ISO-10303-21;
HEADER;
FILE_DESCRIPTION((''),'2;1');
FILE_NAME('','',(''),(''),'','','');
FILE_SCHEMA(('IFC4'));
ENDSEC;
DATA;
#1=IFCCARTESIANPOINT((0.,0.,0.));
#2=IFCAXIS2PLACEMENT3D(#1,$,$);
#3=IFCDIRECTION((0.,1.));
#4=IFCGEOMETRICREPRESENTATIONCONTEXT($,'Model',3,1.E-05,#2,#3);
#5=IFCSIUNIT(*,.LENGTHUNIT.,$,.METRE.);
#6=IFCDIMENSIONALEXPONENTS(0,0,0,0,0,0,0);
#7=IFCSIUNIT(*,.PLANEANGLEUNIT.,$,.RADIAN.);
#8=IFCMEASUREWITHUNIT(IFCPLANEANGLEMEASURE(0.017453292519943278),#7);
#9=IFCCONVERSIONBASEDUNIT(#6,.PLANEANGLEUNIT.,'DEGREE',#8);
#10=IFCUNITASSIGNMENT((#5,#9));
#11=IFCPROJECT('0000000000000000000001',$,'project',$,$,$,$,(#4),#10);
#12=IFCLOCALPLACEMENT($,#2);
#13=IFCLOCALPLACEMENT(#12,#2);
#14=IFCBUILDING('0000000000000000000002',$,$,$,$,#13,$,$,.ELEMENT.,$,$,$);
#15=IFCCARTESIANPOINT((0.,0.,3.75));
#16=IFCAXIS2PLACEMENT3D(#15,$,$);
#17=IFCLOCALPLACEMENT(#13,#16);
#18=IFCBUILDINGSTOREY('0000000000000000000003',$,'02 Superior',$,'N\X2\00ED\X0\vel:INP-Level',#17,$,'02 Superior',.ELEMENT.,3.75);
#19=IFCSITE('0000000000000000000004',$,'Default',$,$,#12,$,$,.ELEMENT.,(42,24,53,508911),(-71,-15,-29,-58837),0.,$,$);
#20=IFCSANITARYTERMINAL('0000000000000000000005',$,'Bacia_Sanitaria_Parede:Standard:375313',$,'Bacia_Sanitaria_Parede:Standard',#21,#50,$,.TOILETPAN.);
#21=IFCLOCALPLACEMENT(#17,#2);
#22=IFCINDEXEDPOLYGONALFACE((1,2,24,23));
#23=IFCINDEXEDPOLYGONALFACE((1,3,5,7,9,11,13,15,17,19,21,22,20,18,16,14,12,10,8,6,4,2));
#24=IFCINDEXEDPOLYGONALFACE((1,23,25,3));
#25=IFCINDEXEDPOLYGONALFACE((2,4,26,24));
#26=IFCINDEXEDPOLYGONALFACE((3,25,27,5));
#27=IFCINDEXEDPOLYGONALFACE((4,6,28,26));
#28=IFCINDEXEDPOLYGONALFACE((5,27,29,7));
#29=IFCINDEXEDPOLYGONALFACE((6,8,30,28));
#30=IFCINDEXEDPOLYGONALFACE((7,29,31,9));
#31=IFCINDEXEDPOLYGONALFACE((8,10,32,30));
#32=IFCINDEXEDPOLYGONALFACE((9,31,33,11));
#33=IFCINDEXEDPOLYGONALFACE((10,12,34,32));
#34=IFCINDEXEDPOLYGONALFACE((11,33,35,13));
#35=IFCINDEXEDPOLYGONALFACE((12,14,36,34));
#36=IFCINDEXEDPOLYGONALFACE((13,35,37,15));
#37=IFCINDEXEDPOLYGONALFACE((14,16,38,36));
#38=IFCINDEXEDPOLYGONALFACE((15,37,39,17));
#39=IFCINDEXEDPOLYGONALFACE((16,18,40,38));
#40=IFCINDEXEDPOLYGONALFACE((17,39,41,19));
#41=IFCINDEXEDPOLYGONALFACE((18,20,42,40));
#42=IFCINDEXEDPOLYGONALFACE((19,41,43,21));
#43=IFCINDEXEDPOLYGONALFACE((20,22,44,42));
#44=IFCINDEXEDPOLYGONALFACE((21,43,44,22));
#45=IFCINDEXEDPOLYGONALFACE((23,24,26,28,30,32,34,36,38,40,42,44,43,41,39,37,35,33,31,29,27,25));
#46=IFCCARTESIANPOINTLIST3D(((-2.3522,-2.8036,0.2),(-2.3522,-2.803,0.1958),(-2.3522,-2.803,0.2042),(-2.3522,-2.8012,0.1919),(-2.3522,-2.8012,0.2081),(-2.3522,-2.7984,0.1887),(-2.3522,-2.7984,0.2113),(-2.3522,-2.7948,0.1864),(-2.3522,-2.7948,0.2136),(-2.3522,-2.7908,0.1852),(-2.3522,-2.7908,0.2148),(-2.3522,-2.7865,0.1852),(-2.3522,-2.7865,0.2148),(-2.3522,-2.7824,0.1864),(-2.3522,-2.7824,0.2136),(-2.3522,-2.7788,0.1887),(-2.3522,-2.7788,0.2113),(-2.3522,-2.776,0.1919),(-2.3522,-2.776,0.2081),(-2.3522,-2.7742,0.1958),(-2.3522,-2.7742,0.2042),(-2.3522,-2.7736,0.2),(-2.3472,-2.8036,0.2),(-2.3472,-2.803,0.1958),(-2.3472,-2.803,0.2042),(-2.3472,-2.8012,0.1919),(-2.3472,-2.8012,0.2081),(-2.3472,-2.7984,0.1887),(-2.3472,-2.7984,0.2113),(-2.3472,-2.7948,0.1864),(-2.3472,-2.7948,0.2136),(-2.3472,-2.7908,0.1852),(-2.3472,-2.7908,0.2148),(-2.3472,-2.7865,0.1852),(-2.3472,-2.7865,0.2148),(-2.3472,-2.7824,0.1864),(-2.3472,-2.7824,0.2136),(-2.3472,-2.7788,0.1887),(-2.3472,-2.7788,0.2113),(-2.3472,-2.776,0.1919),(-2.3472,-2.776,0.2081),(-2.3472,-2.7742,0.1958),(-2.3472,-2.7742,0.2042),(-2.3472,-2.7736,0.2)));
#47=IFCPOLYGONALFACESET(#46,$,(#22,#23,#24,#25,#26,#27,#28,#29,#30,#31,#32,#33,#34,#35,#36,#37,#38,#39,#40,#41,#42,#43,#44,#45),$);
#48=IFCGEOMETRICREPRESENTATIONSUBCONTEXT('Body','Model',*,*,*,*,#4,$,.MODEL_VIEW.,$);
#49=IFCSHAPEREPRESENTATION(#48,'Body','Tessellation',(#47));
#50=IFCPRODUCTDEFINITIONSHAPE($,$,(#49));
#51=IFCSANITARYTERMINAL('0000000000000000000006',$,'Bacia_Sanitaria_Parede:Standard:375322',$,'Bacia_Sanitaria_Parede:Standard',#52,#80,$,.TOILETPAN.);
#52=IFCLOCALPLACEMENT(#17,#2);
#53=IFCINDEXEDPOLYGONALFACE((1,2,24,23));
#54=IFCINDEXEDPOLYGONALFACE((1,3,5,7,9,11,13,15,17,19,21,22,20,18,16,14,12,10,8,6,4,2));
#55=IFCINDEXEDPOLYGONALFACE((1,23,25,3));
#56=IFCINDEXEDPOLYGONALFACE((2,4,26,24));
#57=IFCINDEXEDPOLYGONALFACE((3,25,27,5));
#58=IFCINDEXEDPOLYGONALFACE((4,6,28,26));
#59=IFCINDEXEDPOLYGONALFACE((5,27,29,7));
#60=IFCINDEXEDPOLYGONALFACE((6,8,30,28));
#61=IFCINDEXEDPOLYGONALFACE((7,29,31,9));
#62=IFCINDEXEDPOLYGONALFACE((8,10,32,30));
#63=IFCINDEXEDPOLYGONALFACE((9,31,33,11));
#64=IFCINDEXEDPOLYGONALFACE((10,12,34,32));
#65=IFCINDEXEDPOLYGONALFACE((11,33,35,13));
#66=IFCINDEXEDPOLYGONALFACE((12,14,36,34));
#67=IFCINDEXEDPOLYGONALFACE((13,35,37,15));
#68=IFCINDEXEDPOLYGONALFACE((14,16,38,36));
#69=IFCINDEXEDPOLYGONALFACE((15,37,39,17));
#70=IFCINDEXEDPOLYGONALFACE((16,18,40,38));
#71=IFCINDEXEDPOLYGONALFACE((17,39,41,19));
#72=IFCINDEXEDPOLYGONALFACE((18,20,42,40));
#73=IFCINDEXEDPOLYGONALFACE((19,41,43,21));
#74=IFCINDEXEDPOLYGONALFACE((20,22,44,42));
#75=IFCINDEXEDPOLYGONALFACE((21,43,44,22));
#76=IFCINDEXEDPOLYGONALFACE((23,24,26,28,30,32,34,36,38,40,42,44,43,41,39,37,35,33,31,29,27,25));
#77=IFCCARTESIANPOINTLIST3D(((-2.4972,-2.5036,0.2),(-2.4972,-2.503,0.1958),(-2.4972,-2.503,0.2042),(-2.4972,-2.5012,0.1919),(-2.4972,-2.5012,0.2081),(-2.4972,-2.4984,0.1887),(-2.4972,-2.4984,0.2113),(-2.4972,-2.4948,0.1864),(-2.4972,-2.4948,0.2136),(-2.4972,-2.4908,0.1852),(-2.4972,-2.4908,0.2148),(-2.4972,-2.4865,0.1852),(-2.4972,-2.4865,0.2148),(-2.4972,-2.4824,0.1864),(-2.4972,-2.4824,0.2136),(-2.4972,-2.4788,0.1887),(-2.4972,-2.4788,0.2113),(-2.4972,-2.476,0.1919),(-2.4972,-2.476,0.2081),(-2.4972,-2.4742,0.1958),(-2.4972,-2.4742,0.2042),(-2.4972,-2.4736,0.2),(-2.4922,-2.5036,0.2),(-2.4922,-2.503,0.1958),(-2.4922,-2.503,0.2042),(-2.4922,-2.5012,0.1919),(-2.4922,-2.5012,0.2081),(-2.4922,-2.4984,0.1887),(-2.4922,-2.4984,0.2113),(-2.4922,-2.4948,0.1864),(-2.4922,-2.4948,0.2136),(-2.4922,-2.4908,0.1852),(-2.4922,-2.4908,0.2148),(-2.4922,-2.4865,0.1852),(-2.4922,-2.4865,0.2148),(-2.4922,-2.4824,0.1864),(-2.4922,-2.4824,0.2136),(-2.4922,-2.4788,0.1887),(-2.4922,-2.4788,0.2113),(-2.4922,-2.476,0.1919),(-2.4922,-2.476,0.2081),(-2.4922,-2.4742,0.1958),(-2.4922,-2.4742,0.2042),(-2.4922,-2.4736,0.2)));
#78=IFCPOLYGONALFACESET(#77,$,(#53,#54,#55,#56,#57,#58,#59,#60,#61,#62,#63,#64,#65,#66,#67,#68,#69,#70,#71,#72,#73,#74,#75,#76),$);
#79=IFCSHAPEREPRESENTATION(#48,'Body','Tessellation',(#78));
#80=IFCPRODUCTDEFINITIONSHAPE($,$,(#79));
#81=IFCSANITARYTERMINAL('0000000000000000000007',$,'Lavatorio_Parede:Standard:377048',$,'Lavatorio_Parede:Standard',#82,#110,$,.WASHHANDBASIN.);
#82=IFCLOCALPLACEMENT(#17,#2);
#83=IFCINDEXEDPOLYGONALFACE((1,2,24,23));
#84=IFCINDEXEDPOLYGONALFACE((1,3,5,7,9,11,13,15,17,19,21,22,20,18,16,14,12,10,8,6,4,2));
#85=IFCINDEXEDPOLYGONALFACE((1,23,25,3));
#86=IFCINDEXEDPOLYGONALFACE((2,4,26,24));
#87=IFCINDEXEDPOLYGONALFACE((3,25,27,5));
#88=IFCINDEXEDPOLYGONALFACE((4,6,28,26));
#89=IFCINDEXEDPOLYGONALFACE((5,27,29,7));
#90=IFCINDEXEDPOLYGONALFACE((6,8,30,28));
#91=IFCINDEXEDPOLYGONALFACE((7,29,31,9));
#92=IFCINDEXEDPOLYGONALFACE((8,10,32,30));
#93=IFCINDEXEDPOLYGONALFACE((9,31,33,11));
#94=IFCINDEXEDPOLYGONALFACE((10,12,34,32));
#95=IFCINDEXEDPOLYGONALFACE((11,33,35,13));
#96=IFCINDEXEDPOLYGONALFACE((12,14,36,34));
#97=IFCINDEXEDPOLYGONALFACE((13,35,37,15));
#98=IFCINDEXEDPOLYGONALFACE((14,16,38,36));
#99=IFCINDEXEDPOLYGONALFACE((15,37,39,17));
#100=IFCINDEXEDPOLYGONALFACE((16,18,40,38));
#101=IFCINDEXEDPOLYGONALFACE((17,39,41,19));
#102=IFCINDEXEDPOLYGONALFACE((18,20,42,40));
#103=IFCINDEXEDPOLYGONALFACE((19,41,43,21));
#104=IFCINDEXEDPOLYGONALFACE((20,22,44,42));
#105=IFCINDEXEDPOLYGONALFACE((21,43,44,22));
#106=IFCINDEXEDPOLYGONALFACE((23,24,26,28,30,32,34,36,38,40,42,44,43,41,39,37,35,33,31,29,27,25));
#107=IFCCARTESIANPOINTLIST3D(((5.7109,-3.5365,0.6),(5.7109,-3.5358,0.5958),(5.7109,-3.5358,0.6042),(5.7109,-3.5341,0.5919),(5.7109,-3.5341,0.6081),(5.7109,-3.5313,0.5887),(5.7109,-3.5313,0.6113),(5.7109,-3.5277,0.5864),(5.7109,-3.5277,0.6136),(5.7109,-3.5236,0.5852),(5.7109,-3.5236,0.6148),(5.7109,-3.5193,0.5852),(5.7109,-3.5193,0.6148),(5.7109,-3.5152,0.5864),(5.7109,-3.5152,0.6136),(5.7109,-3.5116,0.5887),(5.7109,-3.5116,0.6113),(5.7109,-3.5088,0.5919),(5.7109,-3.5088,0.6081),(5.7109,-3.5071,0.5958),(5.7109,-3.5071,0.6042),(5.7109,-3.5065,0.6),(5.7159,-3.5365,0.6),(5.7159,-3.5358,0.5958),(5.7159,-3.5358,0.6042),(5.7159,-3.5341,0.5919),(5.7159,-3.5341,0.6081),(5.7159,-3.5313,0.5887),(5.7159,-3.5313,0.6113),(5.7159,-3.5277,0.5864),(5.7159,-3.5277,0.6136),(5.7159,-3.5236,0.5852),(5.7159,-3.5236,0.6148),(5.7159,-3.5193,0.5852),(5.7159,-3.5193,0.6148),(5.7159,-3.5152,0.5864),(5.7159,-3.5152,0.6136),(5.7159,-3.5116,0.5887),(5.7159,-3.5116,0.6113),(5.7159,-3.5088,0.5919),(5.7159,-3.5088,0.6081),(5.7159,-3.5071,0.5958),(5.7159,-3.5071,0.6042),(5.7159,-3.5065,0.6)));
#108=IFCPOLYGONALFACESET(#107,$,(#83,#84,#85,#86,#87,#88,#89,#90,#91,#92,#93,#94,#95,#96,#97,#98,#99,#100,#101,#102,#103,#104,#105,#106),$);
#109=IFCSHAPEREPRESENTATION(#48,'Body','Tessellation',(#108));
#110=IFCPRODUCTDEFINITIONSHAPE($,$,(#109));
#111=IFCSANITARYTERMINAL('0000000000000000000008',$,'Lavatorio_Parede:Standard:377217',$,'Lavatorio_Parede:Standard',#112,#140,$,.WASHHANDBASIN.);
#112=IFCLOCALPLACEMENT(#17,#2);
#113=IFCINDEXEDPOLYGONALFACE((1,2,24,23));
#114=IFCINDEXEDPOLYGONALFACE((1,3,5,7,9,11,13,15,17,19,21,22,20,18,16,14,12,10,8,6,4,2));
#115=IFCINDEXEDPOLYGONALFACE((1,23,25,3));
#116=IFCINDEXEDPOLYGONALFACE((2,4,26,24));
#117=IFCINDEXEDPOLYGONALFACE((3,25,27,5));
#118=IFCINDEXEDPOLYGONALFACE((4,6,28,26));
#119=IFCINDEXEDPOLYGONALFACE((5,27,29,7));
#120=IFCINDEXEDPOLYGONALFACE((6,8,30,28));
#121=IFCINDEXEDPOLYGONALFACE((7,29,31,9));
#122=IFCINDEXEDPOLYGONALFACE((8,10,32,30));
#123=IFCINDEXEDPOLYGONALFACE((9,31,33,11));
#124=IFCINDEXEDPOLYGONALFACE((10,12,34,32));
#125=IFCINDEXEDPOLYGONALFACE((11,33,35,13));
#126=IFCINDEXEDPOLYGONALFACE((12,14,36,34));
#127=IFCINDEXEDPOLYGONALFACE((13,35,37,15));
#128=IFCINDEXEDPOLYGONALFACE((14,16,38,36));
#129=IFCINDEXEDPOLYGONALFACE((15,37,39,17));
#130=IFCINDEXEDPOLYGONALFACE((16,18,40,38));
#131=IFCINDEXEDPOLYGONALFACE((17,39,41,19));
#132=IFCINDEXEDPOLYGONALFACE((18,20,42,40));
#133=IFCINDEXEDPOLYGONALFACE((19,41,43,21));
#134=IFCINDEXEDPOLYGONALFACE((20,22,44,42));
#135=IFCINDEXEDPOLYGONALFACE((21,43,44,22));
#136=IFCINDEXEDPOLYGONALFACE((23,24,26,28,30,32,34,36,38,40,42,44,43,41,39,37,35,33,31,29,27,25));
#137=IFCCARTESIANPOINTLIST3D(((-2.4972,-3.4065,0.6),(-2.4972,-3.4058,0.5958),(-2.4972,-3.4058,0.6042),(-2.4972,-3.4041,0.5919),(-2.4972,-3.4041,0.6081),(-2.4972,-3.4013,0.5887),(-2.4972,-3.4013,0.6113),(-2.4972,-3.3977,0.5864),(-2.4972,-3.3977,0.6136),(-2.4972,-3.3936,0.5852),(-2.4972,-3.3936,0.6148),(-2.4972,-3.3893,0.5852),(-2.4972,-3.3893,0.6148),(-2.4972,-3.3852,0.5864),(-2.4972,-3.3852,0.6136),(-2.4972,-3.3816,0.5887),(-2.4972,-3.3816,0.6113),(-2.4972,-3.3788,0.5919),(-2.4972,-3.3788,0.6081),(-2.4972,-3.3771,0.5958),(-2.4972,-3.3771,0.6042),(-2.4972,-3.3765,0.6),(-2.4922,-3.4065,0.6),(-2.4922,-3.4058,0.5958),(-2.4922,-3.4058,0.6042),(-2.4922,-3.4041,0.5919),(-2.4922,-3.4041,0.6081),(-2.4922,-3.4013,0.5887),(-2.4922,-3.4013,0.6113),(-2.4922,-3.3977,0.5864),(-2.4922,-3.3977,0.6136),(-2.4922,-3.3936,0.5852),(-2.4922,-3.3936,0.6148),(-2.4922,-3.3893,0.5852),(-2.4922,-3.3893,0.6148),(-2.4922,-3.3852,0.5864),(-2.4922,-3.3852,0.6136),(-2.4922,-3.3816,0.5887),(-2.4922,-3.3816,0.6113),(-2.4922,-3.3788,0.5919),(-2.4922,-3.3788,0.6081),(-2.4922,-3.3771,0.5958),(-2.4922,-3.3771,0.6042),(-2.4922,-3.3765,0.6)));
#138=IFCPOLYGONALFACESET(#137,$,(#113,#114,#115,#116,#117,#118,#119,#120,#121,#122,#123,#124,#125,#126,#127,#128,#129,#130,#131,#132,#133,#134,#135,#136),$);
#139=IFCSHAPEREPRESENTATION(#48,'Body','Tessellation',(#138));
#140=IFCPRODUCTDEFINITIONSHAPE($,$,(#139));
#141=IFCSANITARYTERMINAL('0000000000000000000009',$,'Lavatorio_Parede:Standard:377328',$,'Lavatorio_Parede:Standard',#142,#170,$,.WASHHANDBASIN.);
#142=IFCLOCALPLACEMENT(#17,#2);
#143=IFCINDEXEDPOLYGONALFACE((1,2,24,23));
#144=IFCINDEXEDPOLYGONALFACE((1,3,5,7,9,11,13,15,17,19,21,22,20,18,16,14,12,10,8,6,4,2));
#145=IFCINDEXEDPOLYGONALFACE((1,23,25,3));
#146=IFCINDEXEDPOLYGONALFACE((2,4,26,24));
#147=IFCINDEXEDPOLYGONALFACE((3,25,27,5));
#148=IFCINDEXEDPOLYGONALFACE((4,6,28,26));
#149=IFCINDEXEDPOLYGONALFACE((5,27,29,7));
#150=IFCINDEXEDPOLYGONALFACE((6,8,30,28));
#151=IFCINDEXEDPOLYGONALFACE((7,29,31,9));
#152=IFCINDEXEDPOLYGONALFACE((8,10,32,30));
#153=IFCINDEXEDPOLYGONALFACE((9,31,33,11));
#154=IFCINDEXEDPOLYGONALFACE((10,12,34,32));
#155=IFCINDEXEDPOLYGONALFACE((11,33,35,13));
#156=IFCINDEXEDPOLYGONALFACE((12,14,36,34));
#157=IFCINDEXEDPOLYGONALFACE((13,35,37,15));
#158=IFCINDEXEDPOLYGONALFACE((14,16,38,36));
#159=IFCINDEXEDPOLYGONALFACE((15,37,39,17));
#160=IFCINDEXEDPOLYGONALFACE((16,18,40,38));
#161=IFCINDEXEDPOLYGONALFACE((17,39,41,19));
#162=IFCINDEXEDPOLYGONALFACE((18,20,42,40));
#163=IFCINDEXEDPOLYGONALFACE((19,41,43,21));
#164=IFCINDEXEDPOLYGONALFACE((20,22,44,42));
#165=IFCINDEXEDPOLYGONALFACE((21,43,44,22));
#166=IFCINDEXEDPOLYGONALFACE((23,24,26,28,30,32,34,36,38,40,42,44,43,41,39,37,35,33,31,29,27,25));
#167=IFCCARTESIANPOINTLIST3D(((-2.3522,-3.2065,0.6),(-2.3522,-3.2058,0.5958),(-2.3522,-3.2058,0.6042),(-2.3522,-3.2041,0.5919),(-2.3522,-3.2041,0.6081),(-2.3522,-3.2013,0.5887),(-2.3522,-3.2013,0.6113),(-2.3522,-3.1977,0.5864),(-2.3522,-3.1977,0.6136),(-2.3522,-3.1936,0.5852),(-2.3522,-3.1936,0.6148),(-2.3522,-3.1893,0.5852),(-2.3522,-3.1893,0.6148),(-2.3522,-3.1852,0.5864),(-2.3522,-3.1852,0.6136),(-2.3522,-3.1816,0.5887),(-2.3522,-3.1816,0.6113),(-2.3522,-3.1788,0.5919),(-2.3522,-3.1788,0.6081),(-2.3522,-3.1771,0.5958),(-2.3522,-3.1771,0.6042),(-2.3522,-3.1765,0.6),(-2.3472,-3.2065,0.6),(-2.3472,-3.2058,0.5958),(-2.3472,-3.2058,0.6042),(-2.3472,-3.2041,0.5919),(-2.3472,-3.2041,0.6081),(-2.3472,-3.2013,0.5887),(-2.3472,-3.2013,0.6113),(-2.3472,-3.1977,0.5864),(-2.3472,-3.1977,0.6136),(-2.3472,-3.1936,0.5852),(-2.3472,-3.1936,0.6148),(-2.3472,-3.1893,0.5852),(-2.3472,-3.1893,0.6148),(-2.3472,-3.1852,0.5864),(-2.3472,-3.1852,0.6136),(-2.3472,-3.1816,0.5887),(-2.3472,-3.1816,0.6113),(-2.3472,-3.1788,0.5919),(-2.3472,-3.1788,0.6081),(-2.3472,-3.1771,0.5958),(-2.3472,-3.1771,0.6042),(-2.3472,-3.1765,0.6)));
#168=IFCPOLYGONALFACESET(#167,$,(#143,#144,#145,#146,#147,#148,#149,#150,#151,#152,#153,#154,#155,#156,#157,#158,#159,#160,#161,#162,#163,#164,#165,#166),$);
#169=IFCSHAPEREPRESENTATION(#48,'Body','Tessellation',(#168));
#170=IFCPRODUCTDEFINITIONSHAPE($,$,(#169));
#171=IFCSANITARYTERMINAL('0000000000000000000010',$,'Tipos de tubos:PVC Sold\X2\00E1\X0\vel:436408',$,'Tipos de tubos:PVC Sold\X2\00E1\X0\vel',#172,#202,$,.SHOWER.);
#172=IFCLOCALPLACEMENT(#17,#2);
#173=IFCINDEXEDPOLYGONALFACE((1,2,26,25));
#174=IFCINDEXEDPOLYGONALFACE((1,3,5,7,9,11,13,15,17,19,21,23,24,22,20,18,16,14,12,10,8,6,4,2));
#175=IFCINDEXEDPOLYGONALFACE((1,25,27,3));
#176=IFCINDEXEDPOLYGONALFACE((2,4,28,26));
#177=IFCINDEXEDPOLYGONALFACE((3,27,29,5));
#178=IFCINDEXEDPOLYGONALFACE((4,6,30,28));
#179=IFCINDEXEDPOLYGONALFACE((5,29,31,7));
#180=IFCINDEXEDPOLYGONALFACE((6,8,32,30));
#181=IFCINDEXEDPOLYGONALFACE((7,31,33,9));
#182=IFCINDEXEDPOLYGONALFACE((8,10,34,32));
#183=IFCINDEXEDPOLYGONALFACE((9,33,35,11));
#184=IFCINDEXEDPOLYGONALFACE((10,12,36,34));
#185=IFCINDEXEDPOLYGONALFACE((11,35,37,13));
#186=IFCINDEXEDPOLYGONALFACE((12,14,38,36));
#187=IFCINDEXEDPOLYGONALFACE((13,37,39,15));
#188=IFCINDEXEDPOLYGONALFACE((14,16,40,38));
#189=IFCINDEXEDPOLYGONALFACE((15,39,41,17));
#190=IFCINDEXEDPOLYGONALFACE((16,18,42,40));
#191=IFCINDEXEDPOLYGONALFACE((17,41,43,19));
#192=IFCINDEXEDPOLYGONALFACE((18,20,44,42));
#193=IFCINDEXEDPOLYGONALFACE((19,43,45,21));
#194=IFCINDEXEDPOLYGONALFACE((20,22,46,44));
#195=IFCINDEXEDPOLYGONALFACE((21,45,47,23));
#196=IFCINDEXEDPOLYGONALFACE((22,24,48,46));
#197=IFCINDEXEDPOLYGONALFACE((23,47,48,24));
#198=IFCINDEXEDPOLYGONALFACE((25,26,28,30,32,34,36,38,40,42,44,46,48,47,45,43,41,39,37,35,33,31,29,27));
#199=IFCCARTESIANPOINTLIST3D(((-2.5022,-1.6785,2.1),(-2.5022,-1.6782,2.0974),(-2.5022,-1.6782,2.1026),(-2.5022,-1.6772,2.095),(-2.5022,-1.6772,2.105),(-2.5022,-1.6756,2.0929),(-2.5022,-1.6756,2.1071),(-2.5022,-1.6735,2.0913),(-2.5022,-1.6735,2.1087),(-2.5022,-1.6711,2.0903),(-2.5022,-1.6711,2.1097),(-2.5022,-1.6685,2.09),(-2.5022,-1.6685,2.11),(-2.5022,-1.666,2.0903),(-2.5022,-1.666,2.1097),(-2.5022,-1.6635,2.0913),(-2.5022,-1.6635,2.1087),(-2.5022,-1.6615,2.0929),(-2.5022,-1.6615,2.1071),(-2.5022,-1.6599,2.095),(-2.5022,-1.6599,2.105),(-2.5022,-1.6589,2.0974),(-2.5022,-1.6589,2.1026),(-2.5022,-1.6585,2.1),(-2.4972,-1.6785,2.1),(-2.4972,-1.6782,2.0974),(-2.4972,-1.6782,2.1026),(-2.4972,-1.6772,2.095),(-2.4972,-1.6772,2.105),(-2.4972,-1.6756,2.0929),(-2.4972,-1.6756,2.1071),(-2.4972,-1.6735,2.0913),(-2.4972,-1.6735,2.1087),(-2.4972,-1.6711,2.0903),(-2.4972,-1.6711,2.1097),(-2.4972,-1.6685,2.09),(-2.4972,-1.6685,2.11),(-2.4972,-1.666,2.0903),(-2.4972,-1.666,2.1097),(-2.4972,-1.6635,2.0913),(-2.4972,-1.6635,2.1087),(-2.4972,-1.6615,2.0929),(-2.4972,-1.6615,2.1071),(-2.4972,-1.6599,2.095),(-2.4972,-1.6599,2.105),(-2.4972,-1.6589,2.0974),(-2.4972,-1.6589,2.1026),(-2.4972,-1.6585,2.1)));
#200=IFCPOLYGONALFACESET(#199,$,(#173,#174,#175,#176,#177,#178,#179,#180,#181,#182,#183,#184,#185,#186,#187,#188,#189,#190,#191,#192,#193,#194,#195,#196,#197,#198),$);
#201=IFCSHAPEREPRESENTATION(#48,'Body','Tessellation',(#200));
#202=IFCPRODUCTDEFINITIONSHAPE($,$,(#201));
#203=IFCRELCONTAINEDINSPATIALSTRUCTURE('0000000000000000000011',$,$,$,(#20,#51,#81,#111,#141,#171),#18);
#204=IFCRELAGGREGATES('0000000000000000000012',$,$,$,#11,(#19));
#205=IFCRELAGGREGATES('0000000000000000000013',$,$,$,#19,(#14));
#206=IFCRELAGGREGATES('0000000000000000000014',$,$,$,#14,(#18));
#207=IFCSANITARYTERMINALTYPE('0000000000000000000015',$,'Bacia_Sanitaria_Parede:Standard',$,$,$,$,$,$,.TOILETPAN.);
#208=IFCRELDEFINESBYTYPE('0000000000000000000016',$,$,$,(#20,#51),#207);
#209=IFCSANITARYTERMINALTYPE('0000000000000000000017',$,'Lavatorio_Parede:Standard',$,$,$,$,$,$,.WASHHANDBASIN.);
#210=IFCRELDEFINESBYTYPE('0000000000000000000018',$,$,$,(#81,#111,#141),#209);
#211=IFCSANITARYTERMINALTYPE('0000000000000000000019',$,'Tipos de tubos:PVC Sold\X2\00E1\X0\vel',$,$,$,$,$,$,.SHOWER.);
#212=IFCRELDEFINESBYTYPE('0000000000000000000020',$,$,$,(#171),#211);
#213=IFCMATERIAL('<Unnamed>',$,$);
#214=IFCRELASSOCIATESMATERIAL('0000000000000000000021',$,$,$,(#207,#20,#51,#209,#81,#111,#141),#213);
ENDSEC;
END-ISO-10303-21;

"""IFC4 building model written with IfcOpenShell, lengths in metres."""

from ifc_helpers import new_model, entity, si_unit, converted_unit, direction, frame, origin, place, context, subcontext, project, spatial, arc, indexed_curve, outline, extrude, source, transform, mapped, material, type_object, type_shapes, element, save


model = new_model("IFC4")

# Units and contexts
model_context = context("Model", 3, precision=1e-05, world=origin(), true_north=direction((0.0, 1.0)))
body_context = subcontext(model_context, "Body", "Model", "MODEL_VIEW")
ifc_project = project(units=[si_unit("LENGTHUNIT", "METRE"), converted_unit("PLANEANGLEUNIT", "DEGREE", entity("IfcPlaneAngleMeasure", 0.017453292519943278), si_unit("PLANEANGLEUNIT", "RADIAN"), dimensions=[0, 0, 0, 0, 0, 0, 0])], contexts=[model_context])

# Site, building, storey
site_placement = place(None, origin())
site = spatial("IfcSite", under=ifc_project, at=site_placement, Name="Default", CompositionType="ELEMENT", RefLatitude=(42, 24, 53, 508911), RefLongitude=(-71, -15, -29, -58837), RefElevation=0.0)
building_placement = place(site_placement, origin())
building = spatial("IfcBuilding", under=site, at=building_placement, CompositionType="ELEMENT")
storey_placement = place(building_placement, frame((0.0, 0.0, 3.75)))
storey = spatial("IfcBuildingStorey", under=building, at=storey_placement, Name="02 Superior", ObjectType="Nível:INP-Level", LongName="02 Superior", CompositionType="ELEMENT", Elevation=3.75)

# Sanitary terminals
ifc_material = material(Name="<Unnamed>")
sanitary_terminal_type_1 = type_object("IfcSanitaryTerminalType", Name="Bacia_Sanitaria_Parede:Standard", PredefinedType="TOILETPAN", material=ifc_material)
shared_shape_1 = source(origin(), body_context, "Body", "SweptSolid", [
    extrude(outline(indexed_curve([(-0.015, 0.0), (0.0, -0.015), (0.015, 0.0), (0.0, 0.015)], segments=[arc(1, 2, 3), arc(3, 4, 1)], self_intersect=False)), frame((0.15, -0.005, 0.2), z_axis=(0.0, 1.0, 0.0), x_axis=(1.0, 0.0, 0.0)), (0.0, 0.0, 1.0), 0.005),
])
type_shapes(sanitary_terminal_type_1, [shared_shape_1])
for number, where, z_axis, x_axis, name in (
    (1, (-2.3472, -2.6386, 0.0), (0.0, 0.0, 1.0), (0.0, -1.0, 0.0), "Bacia_Sanitaria_Parede:Standard:375313"),
    (2, (-2.4972, -2.6386, 0.0), (0.0, 0.0, 1.0), (0.0, 1.0, 0.0), "Bacia_Sanitaria_Parede:Standard:375322"),
):
    element("IfcSanitaryTerminal", number, at=place(storey_placement, frame(where, z_axis=z_axis, x_axis=x_axis)), inside=storey, type_object=sanitary_terminal_type_1, material=ifc_material, Name=name, ObjectType="Bacia_Sanitaria_Parede:Standard", PredefinedType="TOILETPAN", context=body_context, shape_type="MappedRepresentation", body=[
        mapped(shared_shape_1, transform((0.0, 0.0, 0.0), scale=1.0)),
    ])
sanitary_terminal_type_2 = type_object("IfcSanitaryTerminalType", Name="Lavatorio_Parede:Standard", PredefinedType="WASHHANDBASIN", material=ifc_material)
shared_shape_2 = source(origin(), body_context, "Body", "SweptSolid", [
    extrude(outline(indexed_curve([(-0.015, 0.0), (0.0, -0.015), (0.015, 0.0), (0.0, 0.015)], segments=[arc(1, 2, 3), arc(3, 4, 1)], self_intersect=False)), frame((-0.1, -0.005, 0.6), z_axis=(0.0, 1.0, 0.0), x_axis=(1.0, 0.0, 0.0)), (0.0, 0.0, 1.0), 0.005),
])
type_shapes(sanitary_terminal_type_2, [shared_shape_2])
for number, where, z_axis, x_axis, name in (
    (3, (5.7109, -3.4215, 0.0), (0.0, 0.0, 1.0), (0.0, 1.0, 0.0), "Lavatorio_Parede:Standard:377048"),
    (4, (-2.4972, -3.2915, 0.0), (0.0, 0.0, 1.0), (0.0, 1.0, 0.0), "Lavatorio_Parede:Standard:377217"),
    (5, (-2.3472, -3.2915, 0.0), (0.0, 0.0, 1.0), (0.0, -1.0, 0.0), "Lavatorio_Parede:Standard:377328"),
):
    element("IfcSanitaryTerminal", number, at=place(storey_placement, frame(where, z_axis=z_axis, x_axis=x_axis)), inside=storey, type_object=sanitary_terminal_type_2, material=ifc_material, Name=name, ObjectType="Lavatorio_Parede:Standard", PredefinedType="WASHHANDBASIN", context=body_context, shape_type="MappedRepresentation", body=[
        mapped(shared_shape_2, transform((0.0, 0.0, 0.0), scale=1.0)),
    ])
sanitary_terminal_type_3 = type_object("IfcSanitaryTerminalType", Name="Tipos de tubos:PVC Soldável", PredefinedType="SHOWER")
sanitary_terminal_1_placement = place(storey_placement, origin())
element("IfcSanitaryTerminal", 6, at=sanitary_terminal_1_placement, inside=storey, type_object=sanitary_terminal_type_3, Name="Tipos de tubos:PVC Soldável:436408", ObjectType="Tipos de tubos:PVC Soldável", PredefinedType="SHOWER", context=body_context, shape_type="SweptSolid", body=[
    extrude(outline(indexed_curve([(0.01, 0.0), (0.0071, 0.0071), (0.0, 0.01), (-0.0071, 0.0071), (-0.01, 0.0), (-0.0071, -0.0071), (0.0, -0.01), (0.0071, -0.0071)], segments=[arc(1, 2, 3), arc(3, 4, 5), arc(5, 6, 7), arc(7, 8, 1)], self_intersect=False)), frame((-2.5022, -1.6685, 2.1), z_axis=(1.0, 0.0, 0.0), x_axis=(0.0, 1.0, 0.0)), (0.0, 0.0, 1.0), 0.005),
])

save(model, "model.ifc")
